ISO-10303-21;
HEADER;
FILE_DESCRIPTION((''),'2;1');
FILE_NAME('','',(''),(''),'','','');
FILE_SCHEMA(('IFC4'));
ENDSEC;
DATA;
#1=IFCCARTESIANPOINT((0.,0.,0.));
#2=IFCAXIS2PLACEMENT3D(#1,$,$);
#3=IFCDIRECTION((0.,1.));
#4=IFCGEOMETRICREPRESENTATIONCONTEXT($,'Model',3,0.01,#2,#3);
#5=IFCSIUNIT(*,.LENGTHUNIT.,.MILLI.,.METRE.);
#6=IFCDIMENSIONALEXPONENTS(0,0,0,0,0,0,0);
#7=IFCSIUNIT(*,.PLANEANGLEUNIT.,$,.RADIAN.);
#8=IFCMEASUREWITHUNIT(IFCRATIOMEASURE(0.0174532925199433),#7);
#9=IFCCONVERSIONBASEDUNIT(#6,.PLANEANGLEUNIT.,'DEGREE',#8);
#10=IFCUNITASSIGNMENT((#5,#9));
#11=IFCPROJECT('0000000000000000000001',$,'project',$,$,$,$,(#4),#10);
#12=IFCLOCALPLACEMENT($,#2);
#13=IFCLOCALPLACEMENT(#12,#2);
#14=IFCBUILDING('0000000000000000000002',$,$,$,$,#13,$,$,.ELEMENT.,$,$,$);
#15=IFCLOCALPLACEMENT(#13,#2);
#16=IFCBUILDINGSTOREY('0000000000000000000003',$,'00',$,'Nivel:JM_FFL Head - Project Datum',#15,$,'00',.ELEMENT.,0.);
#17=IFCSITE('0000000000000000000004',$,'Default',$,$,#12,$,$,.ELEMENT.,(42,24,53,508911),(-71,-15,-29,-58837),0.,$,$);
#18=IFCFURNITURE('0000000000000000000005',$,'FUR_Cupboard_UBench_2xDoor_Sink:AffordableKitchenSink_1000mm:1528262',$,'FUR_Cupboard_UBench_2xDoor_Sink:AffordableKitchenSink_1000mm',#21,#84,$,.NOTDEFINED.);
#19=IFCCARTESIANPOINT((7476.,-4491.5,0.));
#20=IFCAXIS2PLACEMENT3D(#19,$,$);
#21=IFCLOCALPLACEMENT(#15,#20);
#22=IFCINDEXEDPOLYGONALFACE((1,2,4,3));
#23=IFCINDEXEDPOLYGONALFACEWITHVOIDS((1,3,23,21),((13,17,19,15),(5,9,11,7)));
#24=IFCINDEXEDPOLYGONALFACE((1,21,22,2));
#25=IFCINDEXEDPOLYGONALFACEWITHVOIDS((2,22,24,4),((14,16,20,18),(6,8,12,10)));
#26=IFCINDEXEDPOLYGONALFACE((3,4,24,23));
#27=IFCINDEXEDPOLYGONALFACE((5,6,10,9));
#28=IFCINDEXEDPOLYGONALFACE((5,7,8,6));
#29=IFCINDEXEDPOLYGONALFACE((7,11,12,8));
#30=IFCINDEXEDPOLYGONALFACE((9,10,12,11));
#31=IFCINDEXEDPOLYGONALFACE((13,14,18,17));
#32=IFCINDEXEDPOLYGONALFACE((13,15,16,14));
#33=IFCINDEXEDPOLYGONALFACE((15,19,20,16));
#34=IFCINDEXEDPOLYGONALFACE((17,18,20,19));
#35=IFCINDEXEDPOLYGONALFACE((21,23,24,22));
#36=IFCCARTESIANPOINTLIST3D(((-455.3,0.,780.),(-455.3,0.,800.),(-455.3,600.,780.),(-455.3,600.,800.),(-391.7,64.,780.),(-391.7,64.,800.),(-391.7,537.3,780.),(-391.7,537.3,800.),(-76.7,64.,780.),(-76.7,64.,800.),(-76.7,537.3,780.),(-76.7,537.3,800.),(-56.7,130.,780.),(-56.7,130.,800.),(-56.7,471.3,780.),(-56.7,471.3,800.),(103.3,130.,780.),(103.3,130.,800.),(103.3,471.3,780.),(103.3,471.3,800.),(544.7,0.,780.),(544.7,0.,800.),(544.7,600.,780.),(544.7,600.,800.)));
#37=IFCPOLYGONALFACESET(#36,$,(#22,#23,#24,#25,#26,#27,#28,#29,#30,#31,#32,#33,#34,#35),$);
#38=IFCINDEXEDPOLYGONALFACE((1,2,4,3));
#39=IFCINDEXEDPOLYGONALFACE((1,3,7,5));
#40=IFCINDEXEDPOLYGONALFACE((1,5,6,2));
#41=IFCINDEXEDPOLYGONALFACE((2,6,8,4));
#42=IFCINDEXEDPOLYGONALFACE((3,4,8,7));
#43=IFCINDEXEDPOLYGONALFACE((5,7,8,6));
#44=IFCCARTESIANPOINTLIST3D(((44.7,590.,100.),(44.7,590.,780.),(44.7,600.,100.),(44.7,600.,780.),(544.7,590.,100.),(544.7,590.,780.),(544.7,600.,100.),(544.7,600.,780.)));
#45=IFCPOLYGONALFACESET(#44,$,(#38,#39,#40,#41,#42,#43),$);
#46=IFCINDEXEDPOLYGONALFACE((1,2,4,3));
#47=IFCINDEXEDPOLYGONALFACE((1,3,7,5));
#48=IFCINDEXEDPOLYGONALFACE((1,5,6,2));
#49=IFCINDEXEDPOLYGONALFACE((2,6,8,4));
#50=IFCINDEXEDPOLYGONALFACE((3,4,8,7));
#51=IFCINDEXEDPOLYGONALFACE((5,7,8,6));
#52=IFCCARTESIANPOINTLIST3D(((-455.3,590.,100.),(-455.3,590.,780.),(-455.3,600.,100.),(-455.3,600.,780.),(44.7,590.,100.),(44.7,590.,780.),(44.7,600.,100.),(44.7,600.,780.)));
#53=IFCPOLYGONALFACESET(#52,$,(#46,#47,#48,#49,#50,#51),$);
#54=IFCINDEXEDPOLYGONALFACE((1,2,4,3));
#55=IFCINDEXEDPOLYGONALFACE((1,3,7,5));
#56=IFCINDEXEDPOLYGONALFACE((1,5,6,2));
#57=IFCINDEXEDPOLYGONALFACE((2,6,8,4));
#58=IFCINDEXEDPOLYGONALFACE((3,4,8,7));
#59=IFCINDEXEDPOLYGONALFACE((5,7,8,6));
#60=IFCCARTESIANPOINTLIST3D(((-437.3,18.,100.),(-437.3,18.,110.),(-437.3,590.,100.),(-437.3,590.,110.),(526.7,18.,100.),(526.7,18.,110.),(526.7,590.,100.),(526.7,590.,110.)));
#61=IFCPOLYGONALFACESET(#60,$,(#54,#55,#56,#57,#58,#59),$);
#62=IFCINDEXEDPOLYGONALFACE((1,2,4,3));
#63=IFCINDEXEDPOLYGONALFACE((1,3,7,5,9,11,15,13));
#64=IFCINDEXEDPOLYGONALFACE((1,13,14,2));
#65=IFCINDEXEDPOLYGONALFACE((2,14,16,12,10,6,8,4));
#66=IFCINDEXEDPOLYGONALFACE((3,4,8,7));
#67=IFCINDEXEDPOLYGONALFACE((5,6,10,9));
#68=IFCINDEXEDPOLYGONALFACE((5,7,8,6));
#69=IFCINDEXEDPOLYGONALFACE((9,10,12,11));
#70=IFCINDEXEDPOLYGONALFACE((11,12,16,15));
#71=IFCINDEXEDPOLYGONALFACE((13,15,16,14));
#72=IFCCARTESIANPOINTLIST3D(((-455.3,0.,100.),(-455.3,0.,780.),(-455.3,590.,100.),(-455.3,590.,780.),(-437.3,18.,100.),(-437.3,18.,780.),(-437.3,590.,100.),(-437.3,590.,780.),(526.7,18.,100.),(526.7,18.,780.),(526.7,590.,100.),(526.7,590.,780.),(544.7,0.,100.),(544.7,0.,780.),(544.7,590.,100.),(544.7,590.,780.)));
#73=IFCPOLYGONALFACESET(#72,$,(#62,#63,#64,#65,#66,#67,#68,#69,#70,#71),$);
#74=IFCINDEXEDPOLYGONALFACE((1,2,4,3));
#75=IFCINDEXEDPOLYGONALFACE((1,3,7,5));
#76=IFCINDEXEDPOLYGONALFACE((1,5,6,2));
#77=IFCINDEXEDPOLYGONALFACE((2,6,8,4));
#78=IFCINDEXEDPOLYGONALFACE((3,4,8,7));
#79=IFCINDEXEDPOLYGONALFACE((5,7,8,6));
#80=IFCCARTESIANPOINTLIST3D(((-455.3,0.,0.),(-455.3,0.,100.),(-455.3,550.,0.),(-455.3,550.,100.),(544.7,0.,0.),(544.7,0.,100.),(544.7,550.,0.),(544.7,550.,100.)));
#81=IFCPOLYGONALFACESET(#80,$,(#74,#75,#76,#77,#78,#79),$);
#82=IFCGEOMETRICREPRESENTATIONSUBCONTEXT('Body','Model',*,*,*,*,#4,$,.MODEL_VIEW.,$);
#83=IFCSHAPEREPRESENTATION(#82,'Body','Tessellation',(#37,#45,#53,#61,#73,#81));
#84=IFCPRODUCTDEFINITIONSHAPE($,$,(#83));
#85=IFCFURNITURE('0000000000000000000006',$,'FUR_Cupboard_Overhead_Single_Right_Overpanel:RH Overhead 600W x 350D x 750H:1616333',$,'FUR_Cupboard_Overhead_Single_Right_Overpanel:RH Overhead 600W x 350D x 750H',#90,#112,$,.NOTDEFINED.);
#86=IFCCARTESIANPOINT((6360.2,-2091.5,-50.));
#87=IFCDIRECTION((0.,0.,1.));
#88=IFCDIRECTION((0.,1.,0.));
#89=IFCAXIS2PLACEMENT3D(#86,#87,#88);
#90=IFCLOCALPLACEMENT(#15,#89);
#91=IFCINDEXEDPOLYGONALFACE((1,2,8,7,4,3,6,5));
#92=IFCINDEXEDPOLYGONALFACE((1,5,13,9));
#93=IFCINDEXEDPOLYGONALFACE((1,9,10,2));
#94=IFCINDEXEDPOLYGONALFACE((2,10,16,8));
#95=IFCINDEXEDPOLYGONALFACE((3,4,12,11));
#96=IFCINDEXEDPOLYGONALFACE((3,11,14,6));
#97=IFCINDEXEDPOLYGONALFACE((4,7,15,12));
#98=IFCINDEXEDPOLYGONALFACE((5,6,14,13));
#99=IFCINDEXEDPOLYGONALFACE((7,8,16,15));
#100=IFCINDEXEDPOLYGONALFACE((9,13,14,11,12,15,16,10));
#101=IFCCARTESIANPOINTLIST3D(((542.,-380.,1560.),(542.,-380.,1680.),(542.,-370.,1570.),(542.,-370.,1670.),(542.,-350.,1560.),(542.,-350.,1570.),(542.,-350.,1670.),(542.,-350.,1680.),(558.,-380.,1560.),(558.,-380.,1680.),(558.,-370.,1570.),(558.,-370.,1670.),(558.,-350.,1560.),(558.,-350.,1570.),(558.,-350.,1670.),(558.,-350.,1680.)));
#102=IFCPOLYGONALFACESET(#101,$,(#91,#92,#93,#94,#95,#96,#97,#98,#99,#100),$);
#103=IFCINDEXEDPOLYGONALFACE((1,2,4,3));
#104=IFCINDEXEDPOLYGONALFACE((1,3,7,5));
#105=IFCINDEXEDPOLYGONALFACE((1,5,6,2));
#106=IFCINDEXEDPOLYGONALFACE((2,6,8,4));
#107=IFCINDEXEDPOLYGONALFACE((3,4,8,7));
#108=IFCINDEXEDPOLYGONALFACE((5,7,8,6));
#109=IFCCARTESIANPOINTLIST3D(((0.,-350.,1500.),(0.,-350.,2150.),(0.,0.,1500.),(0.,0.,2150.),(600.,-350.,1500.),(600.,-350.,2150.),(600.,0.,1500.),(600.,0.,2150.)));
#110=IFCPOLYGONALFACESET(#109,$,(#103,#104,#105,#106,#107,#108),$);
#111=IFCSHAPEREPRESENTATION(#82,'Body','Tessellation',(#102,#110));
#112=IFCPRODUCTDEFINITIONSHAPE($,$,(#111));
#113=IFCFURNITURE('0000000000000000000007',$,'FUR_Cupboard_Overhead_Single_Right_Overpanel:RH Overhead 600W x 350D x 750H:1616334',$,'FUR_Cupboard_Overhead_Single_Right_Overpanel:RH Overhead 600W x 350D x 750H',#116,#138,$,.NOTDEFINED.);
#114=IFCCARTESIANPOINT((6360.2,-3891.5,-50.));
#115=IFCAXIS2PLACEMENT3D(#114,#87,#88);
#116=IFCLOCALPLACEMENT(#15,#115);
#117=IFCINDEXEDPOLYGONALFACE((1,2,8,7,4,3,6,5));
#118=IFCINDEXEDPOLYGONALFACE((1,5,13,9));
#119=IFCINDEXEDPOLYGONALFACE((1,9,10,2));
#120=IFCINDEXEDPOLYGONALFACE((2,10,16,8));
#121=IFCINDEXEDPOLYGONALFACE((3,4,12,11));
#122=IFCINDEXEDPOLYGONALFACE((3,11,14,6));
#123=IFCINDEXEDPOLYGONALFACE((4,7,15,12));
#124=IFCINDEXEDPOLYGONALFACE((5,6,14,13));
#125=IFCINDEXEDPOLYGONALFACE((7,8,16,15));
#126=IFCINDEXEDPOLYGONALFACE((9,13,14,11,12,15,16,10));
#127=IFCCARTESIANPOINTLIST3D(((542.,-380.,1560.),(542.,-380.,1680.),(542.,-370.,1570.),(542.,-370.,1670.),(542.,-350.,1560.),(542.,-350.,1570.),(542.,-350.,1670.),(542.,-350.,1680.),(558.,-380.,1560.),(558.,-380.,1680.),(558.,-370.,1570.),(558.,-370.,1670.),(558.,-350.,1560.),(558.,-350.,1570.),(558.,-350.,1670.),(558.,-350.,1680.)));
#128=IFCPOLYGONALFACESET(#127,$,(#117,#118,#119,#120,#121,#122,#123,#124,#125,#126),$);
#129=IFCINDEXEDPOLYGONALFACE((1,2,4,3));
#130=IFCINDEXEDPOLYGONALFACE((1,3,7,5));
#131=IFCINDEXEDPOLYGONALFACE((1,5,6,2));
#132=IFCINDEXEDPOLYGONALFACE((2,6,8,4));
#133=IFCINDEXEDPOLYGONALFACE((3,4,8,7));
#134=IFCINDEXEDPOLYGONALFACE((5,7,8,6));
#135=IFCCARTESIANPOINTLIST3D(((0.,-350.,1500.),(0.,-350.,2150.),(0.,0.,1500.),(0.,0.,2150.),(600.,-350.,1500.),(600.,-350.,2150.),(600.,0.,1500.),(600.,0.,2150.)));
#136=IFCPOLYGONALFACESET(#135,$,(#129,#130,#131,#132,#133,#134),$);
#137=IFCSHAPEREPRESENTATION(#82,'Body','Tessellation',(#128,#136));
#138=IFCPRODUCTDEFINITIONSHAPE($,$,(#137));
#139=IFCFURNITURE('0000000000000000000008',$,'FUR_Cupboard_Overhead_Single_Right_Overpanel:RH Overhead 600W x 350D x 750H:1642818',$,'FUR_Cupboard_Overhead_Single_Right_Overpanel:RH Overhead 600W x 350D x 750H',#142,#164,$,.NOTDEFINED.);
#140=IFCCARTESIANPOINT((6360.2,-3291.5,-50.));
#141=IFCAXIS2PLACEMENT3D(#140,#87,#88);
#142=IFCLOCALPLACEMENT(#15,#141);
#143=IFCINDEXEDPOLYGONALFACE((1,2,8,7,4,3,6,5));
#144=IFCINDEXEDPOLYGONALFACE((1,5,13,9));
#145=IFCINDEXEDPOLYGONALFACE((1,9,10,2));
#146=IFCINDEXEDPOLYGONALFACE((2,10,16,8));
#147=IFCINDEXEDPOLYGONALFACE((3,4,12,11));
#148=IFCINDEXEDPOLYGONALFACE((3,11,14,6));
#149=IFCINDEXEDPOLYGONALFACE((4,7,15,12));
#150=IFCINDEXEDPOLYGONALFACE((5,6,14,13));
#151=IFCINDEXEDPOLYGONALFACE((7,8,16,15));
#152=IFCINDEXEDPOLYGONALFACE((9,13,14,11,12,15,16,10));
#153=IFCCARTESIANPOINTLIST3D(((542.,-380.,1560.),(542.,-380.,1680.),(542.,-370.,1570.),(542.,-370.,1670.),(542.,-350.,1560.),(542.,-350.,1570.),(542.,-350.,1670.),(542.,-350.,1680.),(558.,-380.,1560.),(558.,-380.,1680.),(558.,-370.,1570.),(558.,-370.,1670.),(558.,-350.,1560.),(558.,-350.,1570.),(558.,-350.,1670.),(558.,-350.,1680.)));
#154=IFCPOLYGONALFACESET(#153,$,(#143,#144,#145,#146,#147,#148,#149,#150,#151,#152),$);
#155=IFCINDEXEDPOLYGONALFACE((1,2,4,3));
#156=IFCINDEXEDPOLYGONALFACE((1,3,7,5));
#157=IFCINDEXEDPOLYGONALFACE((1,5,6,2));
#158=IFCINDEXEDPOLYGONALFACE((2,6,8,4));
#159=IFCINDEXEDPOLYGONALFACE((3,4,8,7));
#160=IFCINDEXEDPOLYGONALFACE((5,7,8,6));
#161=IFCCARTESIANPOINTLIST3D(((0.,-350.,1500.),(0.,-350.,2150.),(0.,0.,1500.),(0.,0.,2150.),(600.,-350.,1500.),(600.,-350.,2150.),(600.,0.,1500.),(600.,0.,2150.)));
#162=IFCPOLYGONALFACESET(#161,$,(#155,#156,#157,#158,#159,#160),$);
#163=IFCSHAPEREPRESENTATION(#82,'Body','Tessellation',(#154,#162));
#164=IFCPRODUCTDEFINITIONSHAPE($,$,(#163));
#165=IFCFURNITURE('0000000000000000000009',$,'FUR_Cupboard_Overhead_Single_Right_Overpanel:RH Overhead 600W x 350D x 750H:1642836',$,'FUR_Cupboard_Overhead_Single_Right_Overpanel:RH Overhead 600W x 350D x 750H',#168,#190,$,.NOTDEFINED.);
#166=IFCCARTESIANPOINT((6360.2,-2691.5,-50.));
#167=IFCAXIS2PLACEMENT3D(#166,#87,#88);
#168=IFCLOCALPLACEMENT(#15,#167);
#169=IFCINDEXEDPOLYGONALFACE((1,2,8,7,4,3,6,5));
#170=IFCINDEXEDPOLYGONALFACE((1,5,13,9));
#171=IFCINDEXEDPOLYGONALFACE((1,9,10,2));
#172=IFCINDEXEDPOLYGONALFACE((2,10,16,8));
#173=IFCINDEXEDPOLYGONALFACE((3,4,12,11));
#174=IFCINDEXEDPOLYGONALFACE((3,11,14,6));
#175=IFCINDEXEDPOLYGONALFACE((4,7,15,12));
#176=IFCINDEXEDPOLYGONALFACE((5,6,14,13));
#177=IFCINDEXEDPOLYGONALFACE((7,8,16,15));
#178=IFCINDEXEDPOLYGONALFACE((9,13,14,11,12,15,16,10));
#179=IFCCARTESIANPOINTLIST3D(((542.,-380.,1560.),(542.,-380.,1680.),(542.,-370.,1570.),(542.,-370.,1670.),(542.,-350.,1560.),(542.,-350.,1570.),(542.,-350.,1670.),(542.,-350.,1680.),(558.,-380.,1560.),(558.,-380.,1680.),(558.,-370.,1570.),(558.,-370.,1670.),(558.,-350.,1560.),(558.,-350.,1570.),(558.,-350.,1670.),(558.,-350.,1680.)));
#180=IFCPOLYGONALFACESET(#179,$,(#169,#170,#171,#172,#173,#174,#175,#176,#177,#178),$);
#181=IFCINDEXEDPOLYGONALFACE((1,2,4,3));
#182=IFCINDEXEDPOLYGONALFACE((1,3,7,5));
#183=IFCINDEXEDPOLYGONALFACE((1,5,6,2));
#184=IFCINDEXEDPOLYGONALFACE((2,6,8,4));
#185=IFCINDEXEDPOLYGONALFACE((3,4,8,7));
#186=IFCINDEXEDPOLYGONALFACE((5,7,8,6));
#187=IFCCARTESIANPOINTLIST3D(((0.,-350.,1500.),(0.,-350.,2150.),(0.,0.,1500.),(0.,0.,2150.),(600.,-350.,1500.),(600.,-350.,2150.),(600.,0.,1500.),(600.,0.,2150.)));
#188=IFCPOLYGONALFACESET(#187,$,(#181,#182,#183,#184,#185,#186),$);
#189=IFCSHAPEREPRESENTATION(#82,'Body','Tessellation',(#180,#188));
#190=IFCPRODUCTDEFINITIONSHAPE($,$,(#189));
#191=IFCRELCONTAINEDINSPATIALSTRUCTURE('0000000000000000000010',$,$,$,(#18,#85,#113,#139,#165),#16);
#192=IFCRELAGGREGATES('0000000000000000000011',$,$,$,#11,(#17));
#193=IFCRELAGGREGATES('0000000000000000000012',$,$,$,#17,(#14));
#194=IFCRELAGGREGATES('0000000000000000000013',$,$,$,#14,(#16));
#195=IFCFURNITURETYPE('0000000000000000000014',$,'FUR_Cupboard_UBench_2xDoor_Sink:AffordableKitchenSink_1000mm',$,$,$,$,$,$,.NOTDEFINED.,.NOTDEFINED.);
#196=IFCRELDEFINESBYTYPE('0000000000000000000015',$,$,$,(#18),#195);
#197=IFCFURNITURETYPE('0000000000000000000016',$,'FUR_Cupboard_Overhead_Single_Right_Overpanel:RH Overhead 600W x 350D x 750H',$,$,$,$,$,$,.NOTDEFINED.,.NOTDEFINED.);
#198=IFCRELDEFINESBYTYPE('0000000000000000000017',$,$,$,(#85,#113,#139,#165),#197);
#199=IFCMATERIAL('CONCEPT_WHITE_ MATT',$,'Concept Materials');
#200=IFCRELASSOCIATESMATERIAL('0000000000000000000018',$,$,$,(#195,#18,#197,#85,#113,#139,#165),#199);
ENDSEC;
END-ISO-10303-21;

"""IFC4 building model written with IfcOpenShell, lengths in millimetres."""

from ifc_helpers import new_model, entity, si_unit, converted_unit, direction, frame, origin, place, context, subcontext, project, spatial, indexed_curve, outline, extrude, source, transform, mapped, material, type_object, type_shapes, element, save


model = new_model("IFC4")

# Units and contexts
model_context = context("Model", 3, precision=0.01, world=origin(), true_north=direction((0.0, 1.0)))
body_context = subcontext(model_context, "Body", "Model", "MODEL_VIEW")
ifc_project = project(units=[si_unit("LENGTHUNIT", "METRE", prefix="MILLI"), converted_unit("PLANEANGLEUNIT", "DEGREE", entity("IfcRatioMeasure", 0.0174532925199433), si_unit("PLANEANGLEUNIT", "RADIAN"), dimensions=[0, 0, 0, 0, 0, 0, 0])], contexts=[model_context])

# Site, building, storey
site_placement = place(None, origin())
site = spatial("IfcSite", under=ifc_project, at=site_placement, Name="Default", CompositionType="ELEMENT", RefLatitude=(42, 24, 53, 508911), RefLongitude=(-71, -15, -29, -58837), RefElevation=0.0)
building_placement = place(site_placement, origin())
building = spatial("IfcBuilding", under=site, at=building_placement, CompositionType="ELEMENT")
storey_placement = place(building_placement, origin())
storey = spatial("IfcBuildingStorey", under=building, at=storey_placement, Name="00", ObjectType="Nivel:JM_FFL Head - Project Datum", LongName="00", CompositionType="ELEMENT", Elevation=0.0)

# Furniture
ifc_material_1 = material(Name="CONCEPT_WHITE_ MATT", Category="Concept Materials")
furniture_type_1 = type_object("IfcFurnitureType", Name="FUR_Cupboard_UBench_2xDoor_Sink:AffordableKitchenSink_1000mm", AssemblyPlace="NOTDEFINED", PredefinedType="NOTDEFINED", material=ifc_material_1)
shared_shape_1 = source(origin(), body_context, "Body", "SweptSolid", [
    extrude(outline(indexed_curve([(-300.0, -500.0), (300.0, -500.0), (300.0, 500.0), (-300.0, 500.0), (-300.0, -500.0)], self_intersect=False), holes=[indexed_curve([(-236.0, 436.4), (237.3, 436.4), (237.3, 121.4), (-236.0, 121.4), (-236.0, 436.4)], self_intersect=False), indexed_curve([(-170.0, -58.6), (-170.0, 101.4), (171.3, 101.4), (171.3, -58.6), (-170.0, -58.6)], self_intersect=False)]), frame((44.7, 300.0, 780.0), z_axis=(0.0, 0.0, 1.0), x_axis=(0.0, 1.0, 0.0)), (0.0, 0.0, 1.0), 20.0),
    extrude(outline(indexed_curve([(-5.0, -250.0), (5.0, -250.0), (5.0, 250.0), (-5.0, 250.0), (-5.0, -250.0)], self_intersect=False)), frame((294.7, 595.0, 100.0), z_axis=(0.0, 0.0, 1.0), x_axis=(0.0, 1.0, 0.0)), (0.0, 0.0, 1.0), 680.0),
    extrude(outline(indexed_curve([(-5.0, -250.0), (5.0, -250.0), (5.0, 250.0), (-5.0, 250.0), (-5.0, -250.0)], self_intersect=False)), frame((-205.3, 595.0, 100.0), z_axis=(0.0, 0.0, 1.0), x_axis=(0.0, 1.0, 0.0)), (0.0, 0.0, 1.0), 680.0),
    extrude(outline(indexed_curve([(-286.0, -482.0), (286.0, -482.0), (286.0, 482.0), (-286.0, 482.0), (-286.0, -482.0)], self_intersect=False)), frame((44.7, 304.0, 100.0), z_axis=(0.0, 0.0, 1.0), x_axis=(0.0, 1.0, 0.0)), (0.0, 0.0, 1.0), 10.0),
    extrude(outline(indexed_curve([(-299.5, -500.0), (290.5, -500.0), (290.5, -482.0), (-281.5, -482.0), (-281.5, 482.0), (290.5, 482.0), (290.5, 500.0), (-299.5, 500.0), (-299.5, -500.0)], self_intersect=False)), frame((44.7, 299.5, 100.0), z_axis=(0.0, 0.0, 1.0), x_axis=(0.0, 1.0, 0.0)), (0.0, 0.0, 1.0), 680.0),
    extrude(outline(indexed_curve([(-275.0, -500.0), (275.0, -500.0), (275.0, 500.0), (-275.0, 500.0), (-275.0, -500.0)], self_intersect=False)), frame((44.7, 275.0, 0.0), z_axis=(0.0, 0.0, 1.0), x_axis=(0.0, 1.0, 0.0)), (0.0, 0.0, 1.0), 100.0),
])
type_shapes(furniture_type_1, [shared_shape_1])
furniture_1_placement = place(storey_placement, frame((7476.0, -4491.5, 0.0)))
element("IfcFurniture", 1, at=furniture_1_placement, inside=storey, type_object=furniture_type_1, material=ifc_material_1, Name="FUR_Cupboard_UBench_2xDoor_Sink:AffordableKitchenSink_1000mm:1528262", ObjectType="FUR_Cupboard_UBench_2xDoor_Sink:AffordableKitchenSink_1000mm", PredefinedType="NOTDEFINED", context=body_context, shape_type="MappedRepresentation", body=[
    mapped(shared_shape_1, transform((0.0, 0.0, 0.0), scale=1.0)),
])
furniture_type_2 = type_object("IfcFurnitureType", Name="FUR_Cupboard_Overhead_Single_Right_Overpanel:RH Overhead 600W x 350D x 750H", AssemblyPlace="NOTDEFINED", PredefinedType="NOTDEFINED", material=ifc_material_1)
shared_shape_2 = source(origin(), body_context, "Body", "SweptSolid", [
    extrude(outline(indexed_curve([(-60.0, -17.5), (60.0, -17.5), (60.0, 12.5), (50.0, 12.5), (50.0, -7.5), (-50.0, -7.5), (-50.0, 12.5), (-60.0, 12.5), (-60.0, -17.5)], self_intersect=False)), frame((542.0, -362.5, 1620.0), z_axis=(1.0, 0.0, 0.0), x_axis=(0.0, 0.0, -1.0)), (0.0, 0.0, 1.0), 16.0),
    extrude(outline(indexed_curve([(-175.0, -300.0), (175.0, -300.0), (175.0, 300.0), (-175.0, 300.0), (-175.0, -300.0)], self_intersect=False)), frame((300.0, -175.0, 1500.0), z_axis=(0.0, 0.0, 1.0), x_axis=(0.0, 1.0, 0.0)), (0.0, 0.0, 1.0), 650.0),
])
type_shapes(furniture_type_2, [shared_shape_2])
for number, where, z_axis, x_axis, name in (
    (2, (6360.2, -2091.5, -50.0), (0.0, 0.0, 1.0), (0.0, 1.0, 0.0), "FUR_Cupboard_Overhead_Single_Right_Overpanel:RH Overhead 600W x 350D x 750H:1616333"),
    (3, (6360.2, -3891.5, -50.0), (0.0, 0.0, 1.0), (0.0, 1.0, 0.0), "FUR_Cupboard_Overhead_Single_Right_Overpanel:RH Overhead 600W x 350D x 750H:1616334"),
    (4, (6360.2, -3291.5, -50.0), (0.0, 0.0, 1.0), (0.0, 1.0, 0.0), "FUR_Cupboard_Overhead_Single_Right_Overpanel:RH Overhead 600W x 350D x 750H:1642818"),
    (5, (6360.2, -2691.5, -50.0), (0.0, 0.0, 1.0), (0.0, 1.0, 0.0), "FUR_Cupboard_Overhead_Single_Right_Overpanel:RH Overhead 600W x 350D x 750H:1642836"),
):
    element("IfcFurniture", number, at=place(storey_placement, frame(where, z_axis=z_axis, x_axis=x_axis)), inside=storey, type_object=furniture_type_2, material=ifc_material_1, Name=name, ObjectType="FUR_Cupboard_Overhead_Single_Right_Overpanel:RH Overhead 600W x 350D x 750H", PredefinedType="NOTDEFINED", context=body_context, shape_type="MappedRepresentation", body=[
        mapped(shared_shape_2, transform((0.0, 0.0, 0.0), scale=1.0)),
    ])

save(model, "model.ifc")
